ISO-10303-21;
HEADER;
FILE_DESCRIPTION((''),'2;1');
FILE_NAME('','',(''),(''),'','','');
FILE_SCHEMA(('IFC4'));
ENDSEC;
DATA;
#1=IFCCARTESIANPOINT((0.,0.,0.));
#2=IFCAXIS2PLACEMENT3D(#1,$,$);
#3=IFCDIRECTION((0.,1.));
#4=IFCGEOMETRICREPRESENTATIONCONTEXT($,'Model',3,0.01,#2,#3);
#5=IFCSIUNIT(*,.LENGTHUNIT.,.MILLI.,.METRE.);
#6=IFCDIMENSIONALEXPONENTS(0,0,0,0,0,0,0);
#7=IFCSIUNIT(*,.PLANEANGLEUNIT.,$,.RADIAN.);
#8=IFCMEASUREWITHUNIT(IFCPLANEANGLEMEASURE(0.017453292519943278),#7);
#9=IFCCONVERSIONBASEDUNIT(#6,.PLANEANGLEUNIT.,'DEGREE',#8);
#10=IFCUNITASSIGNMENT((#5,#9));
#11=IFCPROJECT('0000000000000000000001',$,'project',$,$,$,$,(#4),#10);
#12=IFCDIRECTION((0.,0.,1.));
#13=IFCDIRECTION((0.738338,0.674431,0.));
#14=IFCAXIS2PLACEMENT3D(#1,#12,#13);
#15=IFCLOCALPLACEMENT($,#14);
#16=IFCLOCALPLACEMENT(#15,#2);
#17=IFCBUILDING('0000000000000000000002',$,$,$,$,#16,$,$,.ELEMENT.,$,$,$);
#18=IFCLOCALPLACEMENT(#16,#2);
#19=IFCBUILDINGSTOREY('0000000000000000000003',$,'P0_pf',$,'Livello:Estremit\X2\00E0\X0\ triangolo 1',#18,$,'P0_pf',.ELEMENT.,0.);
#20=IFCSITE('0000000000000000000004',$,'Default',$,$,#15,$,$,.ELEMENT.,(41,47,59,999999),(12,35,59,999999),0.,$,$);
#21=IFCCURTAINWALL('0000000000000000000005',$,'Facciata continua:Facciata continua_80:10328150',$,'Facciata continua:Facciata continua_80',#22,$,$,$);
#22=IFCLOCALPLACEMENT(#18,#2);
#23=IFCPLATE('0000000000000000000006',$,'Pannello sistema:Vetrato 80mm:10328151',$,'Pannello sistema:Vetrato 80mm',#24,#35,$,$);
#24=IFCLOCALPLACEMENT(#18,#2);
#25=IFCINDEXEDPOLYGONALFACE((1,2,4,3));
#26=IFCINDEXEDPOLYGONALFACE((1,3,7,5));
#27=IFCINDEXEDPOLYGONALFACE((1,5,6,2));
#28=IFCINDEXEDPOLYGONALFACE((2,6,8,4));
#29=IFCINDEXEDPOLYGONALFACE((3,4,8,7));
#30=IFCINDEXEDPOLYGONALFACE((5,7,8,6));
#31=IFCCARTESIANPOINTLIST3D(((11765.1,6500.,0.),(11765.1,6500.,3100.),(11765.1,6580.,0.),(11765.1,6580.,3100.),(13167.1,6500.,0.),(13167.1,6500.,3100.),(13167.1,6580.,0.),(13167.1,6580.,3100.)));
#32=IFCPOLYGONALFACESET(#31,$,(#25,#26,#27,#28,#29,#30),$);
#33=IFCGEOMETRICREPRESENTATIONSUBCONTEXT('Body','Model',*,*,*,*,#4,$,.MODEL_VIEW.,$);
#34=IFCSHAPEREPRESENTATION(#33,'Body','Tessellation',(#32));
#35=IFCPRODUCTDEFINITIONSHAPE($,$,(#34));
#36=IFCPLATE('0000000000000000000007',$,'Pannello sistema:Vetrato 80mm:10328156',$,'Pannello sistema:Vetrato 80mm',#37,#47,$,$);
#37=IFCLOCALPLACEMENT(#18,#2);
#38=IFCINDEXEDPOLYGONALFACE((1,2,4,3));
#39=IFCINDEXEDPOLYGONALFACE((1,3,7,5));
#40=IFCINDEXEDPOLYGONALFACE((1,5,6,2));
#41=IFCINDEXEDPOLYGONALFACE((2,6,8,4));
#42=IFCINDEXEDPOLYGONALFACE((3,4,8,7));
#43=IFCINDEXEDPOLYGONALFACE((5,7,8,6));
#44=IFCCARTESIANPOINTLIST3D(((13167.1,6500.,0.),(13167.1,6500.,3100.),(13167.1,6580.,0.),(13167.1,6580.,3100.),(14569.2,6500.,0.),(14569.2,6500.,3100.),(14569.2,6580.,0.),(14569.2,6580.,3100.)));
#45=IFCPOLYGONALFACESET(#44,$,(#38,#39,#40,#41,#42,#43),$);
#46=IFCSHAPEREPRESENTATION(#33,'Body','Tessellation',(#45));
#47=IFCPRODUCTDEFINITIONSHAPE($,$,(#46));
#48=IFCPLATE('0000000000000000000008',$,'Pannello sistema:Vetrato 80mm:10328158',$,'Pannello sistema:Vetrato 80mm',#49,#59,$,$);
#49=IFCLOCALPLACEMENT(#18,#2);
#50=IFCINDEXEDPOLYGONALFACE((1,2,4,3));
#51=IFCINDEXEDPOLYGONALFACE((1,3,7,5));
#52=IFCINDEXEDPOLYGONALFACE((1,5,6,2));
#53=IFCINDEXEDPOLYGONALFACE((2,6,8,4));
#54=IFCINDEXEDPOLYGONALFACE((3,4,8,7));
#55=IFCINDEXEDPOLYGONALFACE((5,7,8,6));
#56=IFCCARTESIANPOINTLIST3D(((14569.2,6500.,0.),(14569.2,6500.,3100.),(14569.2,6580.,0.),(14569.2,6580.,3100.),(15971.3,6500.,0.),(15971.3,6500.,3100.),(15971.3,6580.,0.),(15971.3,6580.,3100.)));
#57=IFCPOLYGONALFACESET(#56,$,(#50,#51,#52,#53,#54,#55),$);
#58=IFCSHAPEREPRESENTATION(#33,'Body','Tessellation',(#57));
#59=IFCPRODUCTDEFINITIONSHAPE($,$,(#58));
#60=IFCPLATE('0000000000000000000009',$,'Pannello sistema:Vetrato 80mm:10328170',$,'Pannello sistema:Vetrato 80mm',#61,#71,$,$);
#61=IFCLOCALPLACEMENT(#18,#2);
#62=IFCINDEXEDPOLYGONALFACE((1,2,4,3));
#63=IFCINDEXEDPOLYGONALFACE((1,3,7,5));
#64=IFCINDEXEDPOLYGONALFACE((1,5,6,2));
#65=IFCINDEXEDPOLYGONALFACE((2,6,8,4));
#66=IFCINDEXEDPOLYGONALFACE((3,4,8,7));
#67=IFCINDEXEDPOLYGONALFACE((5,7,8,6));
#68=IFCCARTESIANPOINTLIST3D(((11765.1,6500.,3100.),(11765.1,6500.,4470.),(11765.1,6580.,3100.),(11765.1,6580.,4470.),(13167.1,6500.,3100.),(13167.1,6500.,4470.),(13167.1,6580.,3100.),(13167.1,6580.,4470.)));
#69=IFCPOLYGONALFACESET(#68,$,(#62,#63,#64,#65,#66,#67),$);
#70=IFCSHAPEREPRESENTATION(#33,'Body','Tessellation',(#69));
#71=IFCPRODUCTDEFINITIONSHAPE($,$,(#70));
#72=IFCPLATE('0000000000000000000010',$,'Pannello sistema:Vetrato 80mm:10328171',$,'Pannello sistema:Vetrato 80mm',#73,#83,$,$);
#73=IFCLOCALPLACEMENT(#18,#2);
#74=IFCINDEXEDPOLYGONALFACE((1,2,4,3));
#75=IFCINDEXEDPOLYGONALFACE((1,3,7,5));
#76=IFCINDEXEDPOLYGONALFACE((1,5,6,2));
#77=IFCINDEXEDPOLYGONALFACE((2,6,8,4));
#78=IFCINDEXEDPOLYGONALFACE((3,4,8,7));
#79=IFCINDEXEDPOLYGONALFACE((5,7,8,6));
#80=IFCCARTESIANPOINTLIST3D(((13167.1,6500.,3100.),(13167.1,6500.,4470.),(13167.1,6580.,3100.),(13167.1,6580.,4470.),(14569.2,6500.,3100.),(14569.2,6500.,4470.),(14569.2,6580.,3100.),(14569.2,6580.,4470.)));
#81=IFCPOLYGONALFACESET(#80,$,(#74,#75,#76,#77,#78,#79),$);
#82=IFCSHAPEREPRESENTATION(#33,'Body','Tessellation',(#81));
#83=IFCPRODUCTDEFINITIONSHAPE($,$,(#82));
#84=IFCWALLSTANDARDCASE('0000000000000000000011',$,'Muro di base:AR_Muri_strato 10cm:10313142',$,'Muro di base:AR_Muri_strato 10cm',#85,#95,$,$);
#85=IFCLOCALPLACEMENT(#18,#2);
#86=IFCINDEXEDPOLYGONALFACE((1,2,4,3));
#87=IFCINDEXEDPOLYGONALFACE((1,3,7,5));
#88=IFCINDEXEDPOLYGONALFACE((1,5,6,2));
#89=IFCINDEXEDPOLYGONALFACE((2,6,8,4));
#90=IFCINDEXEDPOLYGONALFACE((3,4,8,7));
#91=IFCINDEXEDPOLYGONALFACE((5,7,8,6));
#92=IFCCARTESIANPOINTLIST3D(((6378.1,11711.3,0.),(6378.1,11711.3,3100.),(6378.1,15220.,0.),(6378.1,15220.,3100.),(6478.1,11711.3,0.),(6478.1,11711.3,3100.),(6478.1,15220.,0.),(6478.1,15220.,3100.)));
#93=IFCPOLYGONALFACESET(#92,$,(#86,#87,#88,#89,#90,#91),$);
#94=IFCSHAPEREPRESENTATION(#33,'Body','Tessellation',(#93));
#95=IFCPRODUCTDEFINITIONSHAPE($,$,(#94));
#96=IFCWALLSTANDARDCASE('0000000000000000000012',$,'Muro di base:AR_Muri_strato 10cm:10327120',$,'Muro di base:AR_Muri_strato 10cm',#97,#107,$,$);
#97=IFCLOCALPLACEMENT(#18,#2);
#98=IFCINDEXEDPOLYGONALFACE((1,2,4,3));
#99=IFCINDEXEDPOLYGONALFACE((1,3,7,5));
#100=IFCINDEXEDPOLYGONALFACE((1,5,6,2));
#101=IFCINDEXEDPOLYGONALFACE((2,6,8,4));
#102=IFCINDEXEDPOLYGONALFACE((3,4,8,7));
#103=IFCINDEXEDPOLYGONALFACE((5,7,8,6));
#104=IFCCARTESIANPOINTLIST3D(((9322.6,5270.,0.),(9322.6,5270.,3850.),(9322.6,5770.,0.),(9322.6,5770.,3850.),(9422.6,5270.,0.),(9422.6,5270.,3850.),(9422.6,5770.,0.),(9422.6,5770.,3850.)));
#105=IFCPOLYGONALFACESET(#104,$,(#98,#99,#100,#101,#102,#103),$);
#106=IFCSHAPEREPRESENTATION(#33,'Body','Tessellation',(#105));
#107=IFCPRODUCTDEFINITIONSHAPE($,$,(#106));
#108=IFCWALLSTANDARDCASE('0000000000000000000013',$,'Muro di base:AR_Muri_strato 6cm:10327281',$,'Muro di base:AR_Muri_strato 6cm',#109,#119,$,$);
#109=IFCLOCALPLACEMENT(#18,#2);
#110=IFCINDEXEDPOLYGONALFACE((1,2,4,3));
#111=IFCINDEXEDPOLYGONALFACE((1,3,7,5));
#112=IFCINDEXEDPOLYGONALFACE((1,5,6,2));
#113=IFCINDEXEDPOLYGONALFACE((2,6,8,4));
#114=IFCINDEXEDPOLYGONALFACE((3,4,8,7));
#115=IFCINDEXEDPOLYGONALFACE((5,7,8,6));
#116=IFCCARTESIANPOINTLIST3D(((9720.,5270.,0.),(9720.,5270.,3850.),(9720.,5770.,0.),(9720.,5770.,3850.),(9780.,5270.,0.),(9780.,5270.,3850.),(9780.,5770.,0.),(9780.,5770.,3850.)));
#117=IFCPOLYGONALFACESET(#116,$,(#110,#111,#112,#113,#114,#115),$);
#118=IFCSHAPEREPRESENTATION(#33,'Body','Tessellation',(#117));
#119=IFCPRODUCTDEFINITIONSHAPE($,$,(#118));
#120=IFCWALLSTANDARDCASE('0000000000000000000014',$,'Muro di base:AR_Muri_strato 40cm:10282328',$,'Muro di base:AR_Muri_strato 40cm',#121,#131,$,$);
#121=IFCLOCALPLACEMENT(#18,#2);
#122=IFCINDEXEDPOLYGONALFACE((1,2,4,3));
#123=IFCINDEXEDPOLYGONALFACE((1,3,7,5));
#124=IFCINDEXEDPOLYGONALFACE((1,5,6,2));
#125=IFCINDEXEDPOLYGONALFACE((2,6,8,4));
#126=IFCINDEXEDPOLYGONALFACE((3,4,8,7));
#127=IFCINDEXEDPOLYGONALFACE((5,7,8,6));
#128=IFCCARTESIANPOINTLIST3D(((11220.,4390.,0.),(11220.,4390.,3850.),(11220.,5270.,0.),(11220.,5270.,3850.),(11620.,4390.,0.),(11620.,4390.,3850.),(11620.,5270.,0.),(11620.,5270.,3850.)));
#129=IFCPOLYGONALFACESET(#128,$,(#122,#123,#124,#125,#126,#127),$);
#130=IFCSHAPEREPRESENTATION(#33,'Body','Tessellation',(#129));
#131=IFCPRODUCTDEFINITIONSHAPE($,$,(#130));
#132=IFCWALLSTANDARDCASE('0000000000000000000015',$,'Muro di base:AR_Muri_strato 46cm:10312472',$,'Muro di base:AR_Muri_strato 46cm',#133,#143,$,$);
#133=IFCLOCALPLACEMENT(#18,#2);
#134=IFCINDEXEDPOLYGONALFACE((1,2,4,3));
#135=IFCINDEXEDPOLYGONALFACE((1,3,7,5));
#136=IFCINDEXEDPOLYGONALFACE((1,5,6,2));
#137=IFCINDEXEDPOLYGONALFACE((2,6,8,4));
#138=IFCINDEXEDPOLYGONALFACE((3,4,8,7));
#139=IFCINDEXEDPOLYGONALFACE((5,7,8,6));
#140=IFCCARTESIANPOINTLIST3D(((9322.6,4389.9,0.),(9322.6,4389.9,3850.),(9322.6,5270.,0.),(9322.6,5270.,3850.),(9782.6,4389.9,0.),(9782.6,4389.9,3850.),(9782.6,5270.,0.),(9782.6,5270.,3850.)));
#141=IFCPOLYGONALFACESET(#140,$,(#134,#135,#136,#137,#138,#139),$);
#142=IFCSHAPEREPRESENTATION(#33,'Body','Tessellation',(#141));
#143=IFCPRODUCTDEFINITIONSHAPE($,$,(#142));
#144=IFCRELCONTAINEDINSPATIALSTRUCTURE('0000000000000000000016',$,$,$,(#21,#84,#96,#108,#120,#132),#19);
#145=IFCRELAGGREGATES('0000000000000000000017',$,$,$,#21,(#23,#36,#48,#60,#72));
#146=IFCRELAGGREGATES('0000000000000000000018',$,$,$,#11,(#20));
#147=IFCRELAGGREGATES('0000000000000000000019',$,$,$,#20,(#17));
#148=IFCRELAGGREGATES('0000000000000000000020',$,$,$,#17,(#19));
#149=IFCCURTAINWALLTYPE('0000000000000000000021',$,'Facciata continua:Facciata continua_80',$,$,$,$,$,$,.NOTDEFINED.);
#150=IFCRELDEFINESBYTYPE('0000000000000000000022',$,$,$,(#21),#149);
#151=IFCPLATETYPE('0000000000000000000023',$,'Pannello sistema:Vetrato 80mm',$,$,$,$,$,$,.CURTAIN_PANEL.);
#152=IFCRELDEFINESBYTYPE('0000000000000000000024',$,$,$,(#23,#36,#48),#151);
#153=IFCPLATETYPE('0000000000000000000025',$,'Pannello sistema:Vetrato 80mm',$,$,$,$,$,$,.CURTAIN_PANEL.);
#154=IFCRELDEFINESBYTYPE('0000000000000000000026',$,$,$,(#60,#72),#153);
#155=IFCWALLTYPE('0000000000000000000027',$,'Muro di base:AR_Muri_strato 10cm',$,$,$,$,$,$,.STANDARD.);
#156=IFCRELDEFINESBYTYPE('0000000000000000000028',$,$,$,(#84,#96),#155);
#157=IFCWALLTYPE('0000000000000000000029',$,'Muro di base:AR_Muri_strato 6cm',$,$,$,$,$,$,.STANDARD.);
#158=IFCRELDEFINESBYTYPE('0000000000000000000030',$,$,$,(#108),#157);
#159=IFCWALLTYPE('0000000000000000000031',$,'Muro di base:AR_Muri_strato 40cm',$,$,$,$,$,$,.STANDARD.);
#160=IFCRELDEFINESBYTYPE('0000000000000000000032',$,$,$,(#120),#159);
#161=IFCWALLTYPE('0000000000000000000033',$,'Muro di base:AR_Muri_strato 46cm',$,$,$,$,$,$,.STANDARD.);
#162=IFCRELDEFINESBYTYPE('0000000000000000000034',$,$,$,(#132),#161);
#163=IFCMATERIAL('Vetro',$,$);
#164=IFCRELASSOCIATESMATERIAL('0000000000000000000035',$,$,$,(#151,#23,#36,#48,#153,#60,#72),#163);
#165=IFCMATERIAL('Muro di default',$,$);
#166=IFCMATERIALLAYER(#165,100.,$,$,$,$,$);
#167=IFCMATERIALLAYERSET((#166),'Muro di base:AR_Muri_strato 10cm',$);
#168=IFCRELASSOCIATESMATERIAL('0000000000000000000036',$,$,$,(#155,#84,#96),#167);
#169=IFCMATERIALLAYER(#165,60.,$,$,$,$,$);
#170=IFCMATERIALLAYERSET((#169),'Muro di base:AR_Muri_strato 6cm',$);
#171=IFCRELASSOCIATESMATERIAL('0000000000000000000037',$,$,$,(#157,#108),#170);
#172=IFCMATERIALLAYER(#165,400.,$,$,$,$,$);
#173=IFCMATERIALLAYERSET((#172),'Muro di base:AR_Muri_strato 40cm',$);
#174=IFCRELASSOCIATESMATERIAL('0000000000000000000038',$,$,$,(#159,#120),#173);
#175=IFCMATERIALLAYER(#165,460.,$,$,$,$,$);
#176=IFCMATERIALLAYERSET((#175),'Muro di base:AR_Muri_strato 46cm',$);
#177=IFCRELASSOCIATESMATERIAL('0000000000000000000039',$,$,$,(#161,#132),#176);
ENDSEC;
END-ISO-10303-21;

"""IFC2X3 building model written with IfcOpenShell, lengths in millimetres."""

from ifc_helpers import new_model, entity, si_unit, converted_unit, direction, frame, frame_2d, origin, origin_2d_with_axis, place, context, subcontext, project, spatial, rectangle, extrude, source, transform, mapped, material, layer, layer_set, layer_usage, type_object, type_shapes, element, aggregate, save


model = new_model("IFC2X3")

# Units and contexts
model_context = context("Model", 3, precision=0.01, world=origin(), true_north=direction((0.0, 1.0)))
body_context = subcontext(model_context, "Body", "Model", "MODEL_VIEW")
ifc_project = project(units=[si_unit("LENGTHUNIT", "METRE", prefix="MILLI"), converted_unit("PLANEANGLEUNIT", "DEGREE", entity("IfcPlaneAngleMeasure", 0.017453292519943278), si_unit("PLANEANGLEUNIT", "RADIAN"), dimensions=[0, 0, 0, 0, 0, 0, 0])], contexts=[model_context])

# Site, building, storey
site_placement = place(None, frame((0.0, 0.0, 0.0), z_axis=(0.0, 0.0, 1.0), x_axis=(0.738338, 0.674431, 0.0)))
site = spatial("IfcSite", under=ifc_project, at=site_placement, Name="Default", CompositionType="ELEMENT", RefLatitude=(41, 47, 59, 999999), RefLongitude=(12, 35, 59, 999999), RefElevation=0.0)
building_placement = place(site_placement, origin())
building = spatial("IfcBuilding", under=site, at=building_placement, CompositionType="ELEMENT")
storey_placement = place(building_placement, origin())
storey = spatial("IfcBuildingStorey", under=building, at=storey_placement, Name="P0_pf", ObjectType="Livello:Estremità triangolo 1", LongName="P0_pf", CompositionType="ELEMENT", Elevation=0.0)

# Curtain wall, plates
curtain_wall_type_1 = type_object("IfcCurtainWallType", Name="Facciata continua:Facciata continua_80", PredefinedType="NOTDEFINED")
ifc_material_1 = material(Name="Vetro")
curtain_wall_1_placement = place(storey_placement, origin())
curtain_wall_1 = element("IfcCurtainWall", 1, at=curtain_wall_1_placement, inside=storey, type_object=curtain_wall_type_1, Name="Facciata continua:Facciata continua_80:10328150", ObjectType="Facciata continua:Facciata continua_80")
plate_type_1 = type_object("IfcPlateType", Name="Pannello sistema:Vetrato 80mm", PredefinedType="CURTAIN_PANEL", material=ifc_material_1)
shared_shape_1 = source(origin(), body_context, "Body", "SweptSolid", [
    extrude(rectangle(XDim=80.0, YDim=1402.1, at=origin_2d_with_axis()), frame((0.0, -40.0, 0.0), z_axis=(0.0, 0.0, 1.0), x_axis=(0.0, 1.0, 0.0)), (0.0, 0.0, 1.0), 3100.0),
])
type_shapes(plate_type_1, [shared_shape_1])
plate_1_placement = place(curtain_wall_1_placement, frame((12466.1, 6580.0, 0.0)))
plate_1 = element("IfcPlate", 2, at=plate_1_placement, type_object=plate_type_1, material=ifc_material_1, Name="Pannello sistema:Vetrato 80mm:10328151", ObjectType="Pannello sistema:Vetrato 80mm", context=body_context, shape_type="MappedRepresentation", body=[
    mapped(shared_shape_1, transform((0.0, 0.0, 0.0), scale=1.0)),
])
plate_2_placement = place(curtain_wall_1_placement, frame((13868.2, 6580.0, 0.0)))
plate_2 = element("IfcPlate", 3, at=plate_2_placement, type_object=plate_type_1, material=ifc_material_1, Name="Pannello sistema:Vetrato 80mm:10328156", ObjectType="Pannello sistema:Vetrato 80mm", context=body_context, shape_type="MappedRepresentation", body=[
    mapped(shared_shape_1, transform((0.0, 0.0, 0.0), scale=1.0)),
])
plate_3_placement = place(curtain_wall_1_placement, frame((15270.2, 6580.0, 0.0)))
plate_3 = element("IfcPlate", 4, at=plate_3_placement, type_object=plate_type_1, material=ifc_material_1, Name="Pannello sistema:Vetrato 80mm:10328158", ObjectType="Pannello sistema:Vetrato 80mm", context=body_context, shape_type="MappedRepresentation", body=[
    mapped(shared_shape_1, transform((0.0, 0.0, 0.0), scale=1.0)),
])
plate_type_2 = type_object("IfcPlateType", Name="Pannello sistema:Vetrato 80mm", PredefinedType="CURTAIN_PANEL", material=ifc_material_1)
shared_shape_2 = source(origin(), body_context, "Body", "SweptSolid", [
    extrude(rectangle(XDim=80.0, YDim=1402.1, at=origin_2d_with_axis()), frame((0.0, -40.0, 0.0), z_axis=(0.0, 0.0, 1.0), x_axis=(0.0, 1.0, 0.0)), (0.0, 0.0, 1.0), 1370.0),
])
type_shapes(plate_type_2, [shared_shape_2])
plate_4_placement = place(curtain_wall_1_placement, frame((12466.1, 6580.0, 3100.0)))
plate_4 = element("IfcPlate", 5, at=plate_4_placement, type_object=plate_type_2, material=ifc_material_1, Name="Pannello sistema:Vetrato 80mm:10328170", ObjectType="Pannello sistema:Vetrato 80mm", context=body_context, shape_type="MappedRepresentation", body=[
    mapped(shared_shape_2, transform((0.0, 0.0, 0.0), scale=1.0)),
])
plate_5_placement = place(curtain_wall_1_placement, frame((13868.2, 6580.0, 3100.0)))
plate_5 = element("IfcPlate", 6, at=plate_5_placement, type_object=plate_type_2, material=ifc_material_1, Name="Pannello sistema:Vetrato 80mm:10328171", ObjectType="Pannello sistema:Vetrato 80mm", context=body_context, shape_type="MappedRepresentation", body=[
    mapped(shared_shape_2, transform((0.0, 0.0, 0.0), scale=1.0)),
])
aggregate(curtain_wall_1, [plate_1, plate_2, plate_3, plate_4, plate_5])

# Shared definitions
ifc_material_2 = material(Name="Muro di default")
ifc_layer_1 = layer(ifc_material_2, 100.0)
ifc_layer_set_1 = layer_set([ifc_layer_1], Name="Muro di base:AR_Muri_strato 10cm")
wall_type_1 = type_object("IfcWallType", Name="Muro di base:AR_Muri_strato 10cm", PredefinedType="STANDARD", material=ifc_layer_set_1)

# Walls
ifc_layer_usage_1 = layer_usage(ifc_layer_set_1, "AXIS2", "NEGATIVE", 50.0)
wall_1_placement = place(storey_placement, frame((6428.1, 11711.3, 0.0), z_axis=(0.0, 0.0, 1.0), x_axis=(0.0, 1.0, 0.0)))
element("IfcWallStandardCase", 7, at=wall_1_placement, inside=storey, type_object=wall_type_1, material=ifc_layer_usage_1, Name="Muro di base:AR_Muri_strato 10cm:10313142", ObjectType="Muro di base:AR_Muri_strato 10cm", context=body_context, shape_type="SweptSolid", body=[
    extrude(rectangle(XDim=3508.7, YDim=100.0, at=frame_2d((1754.4, 0.0), x_axis=(-1.0, 0.0))), origin(), (0.0, 0.0, 1.0), 3100.0),
])
ifc_layer_usage_2 = layer_usage(ifc_layer_set_1, "AXIS2", "NEGATIVE", 50.0)
wall_2_placement = place(storey_placement, frame((9372.6, 5770.0, 0.0), z_axis=(0.0, 0.0, 1.0), x_axis=(0.0, -1.0, 0.0)))
element("IfcWallStandardCase", 8, at=wall_2_placement, inside=storey, type_object=wall_type_1, material=ifc_layer_usage_2, Name="Muro di base:AR_Muri_strato 10cm:10327120", ObjectType="Muro di base:AR_Muri_strato 10cm", context=body_context, shape_type="SweptSolid", body=[
    extrude(rectangle(XDim=500.0, YDim=100.0, at=frame_2d((250.0, 0.0), x_axis=(-1.0, 0.0))), origin(), (0.0, 0.0, 1.0), 3850.0),
])
ifc_layer_2 = layer(ifc_material_2, 60.0)
ifc_layer_set_2 = layer_set([ifc_layer_2], Name="Muro di base:AR_Muri_strato 6cm")
ifc_layer_usage_3 = layer_usage(ifc_layer_set_2, "AXIS2", "POSITIVE", -30.0)
wall_type_2 = type_object("IfcWallType", Name="Muro di base:AR_Muri_strato 6cm", PredefinedType="STANDARD", material=ifc_layer_set_2)
wall_3_placement = place(storey_placement, frame((9750.0, 5770.0, 0.0), z_axis=(0.0, 0.0, 1.0), x_axis=(0.0, -1.0, 0.0)))
element("IfcWallStandardCase", 9, at=wall_3_placement, inside=storey, type_object=wall_type_2, material=ifc_layer_usage_3, Name="Muro di base:AR_Muri_strato 6cm:10327281", ObjectType="Muro di base:AR_Muri_strato 6cm", context=body_context, shape_type="SweptSolid", body=[
    extrude(rectangle(XDim=500.0, YDim=60.0, at=frame_2d((250.0, 0.0), x_axis=(-1.0, 0.0))), origin(), (0.0, 0.0, 1.0), 3850.0),
])
ifc_layer_3 = layer(ifc_material_2, 400.0)
ifc_layer_set_3 = layer_set([ifc_layer_3], Name="Muro di base:AR_Muri_strato 40cm")
ifc_layer_usage_4 = layer_usage(ifc_layer_set_3, "AXIS2", "NEGATIVE", 200.0)
wall_type_3 = type_object("IfcWallType", Name="Muro di base:AR_Muri_strato 40cm", PredefinedType="STANDARD", material=ifc_layer_set_3)
wall_4_placement = place(storey_placement, frame((11420.0, 4390.0, 0.0), z_axis=(0.0, 0.0, 1.0), x_axis=(0.0, 1.0, 0.0)))
element("IfcWallStandardCase", 10, at=wall_4_placement, inside=storey, type_object=wall_type_3, material=ifc_layer_usage_4, Name="Muro di base:AR_Muri_strato 40cm:10282328", ObjectType="Muro di base:AR_Muri_strato 40cm", context=body_context, shape_type="SweptSolid", body=[
    extrude(rectangle(XDim=880.0, YDim=400.0, at=frame_2d((440.0, 0.0), x_axis=(-1.0, 0.0))), origin(), (0.0, 0.0, 1.0), 3850.0),
])
ifc_layer_4 = layer(ifc_material_2, 460.0)
ifc_layer_set_4 = layer_set([ifc_layer_4], Name="Muro di base:AR_Muri_strato 46cm")
ifc_layer_usage_5 = layer_usage(ifc_layer_set_4, "AXIS2", "NEGATIVE", 230.0)
wall_type_4 = type_object("IfcWallType", Name="Muro di base:AR_Muri_strato 46cm", PredefinedType="STANDARD", material=ifc_layer_set_4)
wall_5_placement = place(storey_placement, frame((9552.6, 5270.0, 0.0), z_axis=(0.0, 0.0, 1.0), x_axis=(0.0, -1.0, 0.0)))
element("IfcWallStandardCase", 11, at=wall_5_placement, inside=storey, type_object=wall_type_4, material=ifc_layer_usage_5, Name="Muro di base:AR_Muri_strato 46cm:10312472", ObjectType="Muro di base:AR_Muri_strato 46cm", context=body_context, shape_type="SweptSolid", body=[
    extrude(rectangle(XDim=880.1, YDim=460.0, at=frame_2d((440.0, 0.0), x_axis=(-1.0, 0.0))), origin(), (0.0, 0.0, 1.0), 3850.0),
])

save(model, "model.ifc")
